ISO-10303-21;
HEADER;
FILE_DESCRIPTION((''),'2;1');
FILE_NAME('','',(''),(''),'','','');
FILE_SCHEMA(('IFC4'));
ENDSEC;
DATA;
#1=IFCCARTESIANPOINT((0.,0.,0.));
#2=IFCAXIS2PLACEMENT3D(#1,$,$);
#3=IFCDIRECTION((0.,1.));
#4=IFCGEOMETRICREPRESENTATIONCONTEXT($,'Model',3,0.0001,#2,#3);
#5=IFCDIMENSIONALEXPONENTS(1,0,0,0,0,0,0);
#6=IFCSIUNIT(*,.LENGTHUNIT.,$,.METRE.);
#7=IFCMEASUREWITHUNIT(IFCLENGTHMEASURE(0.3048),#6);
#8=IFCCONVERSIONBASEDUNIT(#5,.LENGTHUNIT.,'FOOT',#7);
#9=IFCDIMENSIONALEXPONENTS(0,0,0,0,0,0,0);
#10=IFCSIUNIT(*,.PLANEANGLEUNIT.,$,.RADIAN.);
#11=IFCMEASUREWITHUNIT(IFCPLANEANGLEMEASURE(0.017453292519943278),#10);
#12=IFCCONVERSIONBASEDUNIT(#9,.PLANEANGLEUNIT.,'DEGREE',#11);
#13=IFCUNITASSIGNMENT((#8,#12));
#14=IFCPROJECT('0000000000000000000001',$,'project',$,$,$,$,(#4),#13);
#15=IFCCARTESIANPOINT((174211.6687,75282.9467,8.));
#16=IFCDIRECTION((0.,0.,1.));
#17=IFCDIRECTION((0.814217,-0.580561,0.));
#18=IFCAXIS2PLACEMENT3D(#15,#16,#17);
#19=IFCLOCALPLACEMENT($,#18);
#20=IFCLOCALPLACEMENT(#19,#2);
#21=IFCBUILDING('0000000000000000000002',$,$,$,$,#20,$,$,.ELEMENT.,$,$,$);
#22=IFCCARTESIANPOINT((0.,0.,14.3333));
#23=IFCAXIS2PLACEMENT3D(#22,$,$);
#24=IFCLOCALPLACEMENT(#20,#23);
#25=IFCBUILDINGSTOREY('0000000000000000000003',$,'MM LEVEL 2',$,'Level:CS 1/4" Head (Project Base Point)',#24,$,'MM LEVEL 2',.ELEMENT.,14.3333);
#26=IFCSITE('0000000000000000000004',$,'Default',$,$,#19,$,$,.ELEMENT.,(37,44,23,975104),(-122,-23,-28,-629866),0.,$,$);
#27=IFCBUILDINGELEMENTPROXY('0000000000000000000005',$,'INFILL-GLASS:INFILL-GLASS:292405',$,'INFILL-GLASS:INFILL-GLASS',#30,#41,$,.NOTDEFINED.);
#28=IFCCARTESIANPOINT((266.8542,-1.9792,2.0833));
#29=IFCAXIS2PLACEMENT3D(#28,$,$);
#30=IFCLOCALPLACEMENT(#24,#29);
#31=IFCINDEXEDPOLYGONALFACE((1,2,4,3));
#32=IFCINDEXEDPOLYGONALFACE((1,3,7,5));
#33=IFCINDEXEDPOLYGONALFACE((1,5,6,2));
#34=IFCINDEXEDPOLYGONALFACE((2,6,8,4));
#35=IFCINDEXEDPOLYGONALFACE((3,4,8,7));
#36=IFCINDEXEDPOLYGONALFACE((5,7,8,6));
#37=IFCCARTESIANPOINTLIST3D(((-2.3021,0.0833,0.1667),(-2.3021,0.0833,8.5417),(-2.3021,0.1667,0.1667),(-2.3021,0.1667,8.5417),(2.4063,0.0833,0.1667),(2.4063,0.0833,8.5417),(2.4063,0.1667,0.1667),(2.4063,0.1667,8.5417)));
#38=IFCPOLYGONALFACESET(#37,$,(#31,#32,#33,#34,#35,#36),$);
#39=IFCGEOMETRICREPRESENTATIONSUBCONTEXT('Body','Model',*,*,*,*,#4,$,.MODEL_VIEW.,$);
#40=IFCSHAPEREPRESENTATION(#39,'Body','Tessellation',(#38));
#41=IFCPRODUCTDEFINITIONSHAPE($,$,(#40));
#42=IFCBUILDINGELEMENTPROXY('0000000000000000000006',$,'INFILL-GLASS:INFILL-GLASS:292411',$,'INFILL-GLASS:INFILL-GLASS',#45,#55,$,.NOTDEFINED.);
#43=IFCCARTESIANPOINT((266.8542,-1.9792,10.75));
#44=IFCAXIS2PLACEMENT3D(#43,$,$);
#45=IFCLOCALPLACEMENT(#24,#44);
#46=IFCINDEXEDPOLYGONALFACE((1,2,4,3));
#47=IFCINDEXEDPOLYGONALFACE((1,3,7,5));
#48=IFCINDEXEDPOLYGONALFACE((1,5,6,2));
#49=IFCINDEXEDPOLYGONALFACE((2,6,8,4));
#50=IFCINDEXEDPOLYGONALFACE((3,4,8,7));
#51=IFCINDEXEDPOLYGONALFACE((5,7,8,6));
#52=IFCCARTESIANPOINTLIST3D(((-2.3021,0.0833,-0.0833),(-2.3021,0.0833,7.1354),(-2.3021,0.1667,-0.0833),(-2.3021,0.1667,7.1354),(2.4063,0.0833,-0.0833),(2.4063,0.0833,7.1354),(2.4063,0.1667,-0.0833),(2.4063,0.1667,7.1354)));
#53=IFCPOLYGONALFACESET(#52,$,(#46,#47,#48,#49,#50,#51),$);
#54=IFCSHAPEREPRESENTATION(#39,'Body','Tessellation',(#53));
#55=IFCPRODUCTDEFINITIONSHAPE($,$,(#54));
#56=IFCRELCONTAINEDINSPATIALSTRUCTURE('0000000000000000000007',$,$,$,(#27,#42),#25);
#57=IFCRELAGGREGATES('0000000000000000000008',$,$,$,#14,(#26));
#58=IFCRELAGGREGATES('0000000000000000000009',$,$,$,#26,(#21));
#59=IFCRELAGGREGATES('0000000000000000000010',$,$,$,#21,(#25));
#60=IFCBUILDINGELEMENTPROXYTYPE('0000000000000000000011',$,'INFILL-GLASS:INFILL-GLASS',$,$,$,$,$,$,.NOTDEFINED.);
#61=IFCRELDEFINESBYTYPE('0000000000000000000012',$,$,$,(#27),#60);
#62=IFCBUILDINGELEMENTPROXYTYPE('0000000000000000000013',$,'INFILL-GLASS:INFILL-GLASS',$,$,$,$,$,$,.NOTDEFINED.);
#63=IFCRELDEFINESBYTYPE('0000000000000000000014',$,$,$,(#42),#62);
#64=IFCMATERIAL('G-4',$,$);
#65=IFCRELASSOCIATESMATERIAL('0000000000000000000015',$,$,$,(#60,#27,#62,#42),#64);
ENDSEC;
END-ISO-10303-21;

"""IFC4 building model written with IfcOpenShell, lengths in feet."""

from ifc_helpers import new_model, entity, si_unit, converted_unit, direction, frame, origin, place, context, subcontext, project, spatial, indexed_curve, outline, extrude, source, transform, mapped, material, type_object, type_shapes, element, save


model = new_model("IFC4")

# Units and contexts
model_context = context("Model", 3, precision=0.0001, world=origin(), true_north=direction((0.0, 1.0)))
body_context = subcontext(model_context, "Body", "Model", "MODEL_VIEW")
ifc_project = project(units=[converted_unit("LENGTHUNIT", "FOOT", entity("IfcLengthMeasure", 0.3048), si_unit("LENGTHUNIT", "METRE"), dimensions=[1, 0, 0, 0, 0, 0, 0]), converted_unit("PLANEANGLEUNIT", "DEGREE", entity("IfcPlaneAngleMeasure", 0.017453292519943278), si_unit("PLANEANGLEUNIT", "RADIAN"), dimensions=[0, 0, 0, 0, 0, 0, 0])], contexts=[model_context])

# Site, building, storey
site_placement = place(None, frame((174211.6687, 75282.9467, 8.0), z_axis=(0.0, 0.0, 1.0), x_axis=(0.814217, -0.580561, 0.0)))
site = spatial("IfcSite", under=ifc_project, at=site_placement, Name="Default", CompositionType="ELEMENT", RefLatitude=(37, 44, 23, 975104), RefLongitude=(-122, -23, -28, -629866), RefElevation=0.0)
building_placement = place(site_placement, origin())
building = spatial("IfcBuilding", under=site, at=building_placement, CompositionType="ELEMENT")
storey_placement = place(building_placement, frame((0.0, 0.0, 14.3333)))
storey = spatial("IfcBuildingStorey", under=building, at=storey_placement, Name="MM LEVEL 2", ObjectType="Level:CS 1/4\" Head (Project Base Point)", LongName="MM LEVEL 2", CompositionType="ELEMENT", Elevation=14.3333)

# Building element proxies
ifc_material_1 = material(Name="G-4")
building_element_proxy_type_1 = type_object("IfcBuildingElementProxyType", Name="INFILL-GLASS:INFILL-GLASS", PredefinedType="NOTDEFINED", material=ifc_material_1)
shared_shape_1 = source(origin(), body_context, "Body", "SweptSolid", [
    extrude(outline(indexed_curve([(-0.0417, -2.3542), (0.0417, -2.3542), (0.0417, 2.3542), (-0.0417, 2.3542), (-0.0417, -2.3542)], self_intersect=False)), frame((0.0521, 0.125, 0.1667), z_axis=(0.0, 0.0, 1.0), x_axis=(0.0, 1.0, 0.0)), (0.0, 0.0, 1.0), 8.375),
])
type_shapes(building_element_proxy_type_1, [shared_shape_1])
proxy_1_placement = place(storey_placement, frame((266.8542, -1.9792, 2.0833)))
element("IfcBuildingElementProxy", 1, at=proxy_1_placement, inside=storey, type_object=building_element_proxy_type_1, material=ifc_material_1, Name="INFILL-GLASS:INFILL-GLASS:292405", ObjectType="INFILL-GLASS:INFILL-GLASS", PredefinedType="NOTDEFINED", context=body_context, shape_type="MappedRepresentation", body=[
    mapped(shared_shape_1, transform((0.0, 0.0, 0.0), scale=1.0)),
])
building_element_proxy_type_2 = type_object("IfcBuildingElementProxyType", Name="INFILL-GLASS:INFILL-GLASS", PredefinedType="NOTDEFINED", material=ifc_material_1)
shared_shape_2 = source(origin(), body_context, "Body", "SweptSolid", [
    extrude(outline(indexed_curve([(-0.0417, -2.3542), (0.0417, -2.3542), (0.0417, 2.3542), (-0.0417, 2.3542), (-0.0417, -2.3542)], self_intersect=False)), frame((0.0521, 0.125, -0.0833), z_axis=(0.0, 0.0, 1.0), x_axis=(0.0, 1.0, 0.0)), (0.0, 0.0, 1.0), 7.2187),
])
type_shapes(building_element_proxy_type_2, [shared_shape_2])
proxy_2_placement = place(storey_placement, frame((266.8542, -1.9792, 10.75)))
element("IfcBuildingElementProxy", 2, at=proxy_2_placement, inside=storey, type_object=building_element_proxy_type_2, material=ifc_material_1, Name="INFILL-GLASS:INFILL-GLASS:292411", ObjectType="INFILL-GLASS:INFILL-GLASS", PredefinedType="NOTDEFINED", context=body_context, shape_type="MappedRepresentation", body=[
    mapped(shared_shape_2, transform((0.0, 0.0, 0.0), scale=1.0)),
])

save(model, "model.ifc")
